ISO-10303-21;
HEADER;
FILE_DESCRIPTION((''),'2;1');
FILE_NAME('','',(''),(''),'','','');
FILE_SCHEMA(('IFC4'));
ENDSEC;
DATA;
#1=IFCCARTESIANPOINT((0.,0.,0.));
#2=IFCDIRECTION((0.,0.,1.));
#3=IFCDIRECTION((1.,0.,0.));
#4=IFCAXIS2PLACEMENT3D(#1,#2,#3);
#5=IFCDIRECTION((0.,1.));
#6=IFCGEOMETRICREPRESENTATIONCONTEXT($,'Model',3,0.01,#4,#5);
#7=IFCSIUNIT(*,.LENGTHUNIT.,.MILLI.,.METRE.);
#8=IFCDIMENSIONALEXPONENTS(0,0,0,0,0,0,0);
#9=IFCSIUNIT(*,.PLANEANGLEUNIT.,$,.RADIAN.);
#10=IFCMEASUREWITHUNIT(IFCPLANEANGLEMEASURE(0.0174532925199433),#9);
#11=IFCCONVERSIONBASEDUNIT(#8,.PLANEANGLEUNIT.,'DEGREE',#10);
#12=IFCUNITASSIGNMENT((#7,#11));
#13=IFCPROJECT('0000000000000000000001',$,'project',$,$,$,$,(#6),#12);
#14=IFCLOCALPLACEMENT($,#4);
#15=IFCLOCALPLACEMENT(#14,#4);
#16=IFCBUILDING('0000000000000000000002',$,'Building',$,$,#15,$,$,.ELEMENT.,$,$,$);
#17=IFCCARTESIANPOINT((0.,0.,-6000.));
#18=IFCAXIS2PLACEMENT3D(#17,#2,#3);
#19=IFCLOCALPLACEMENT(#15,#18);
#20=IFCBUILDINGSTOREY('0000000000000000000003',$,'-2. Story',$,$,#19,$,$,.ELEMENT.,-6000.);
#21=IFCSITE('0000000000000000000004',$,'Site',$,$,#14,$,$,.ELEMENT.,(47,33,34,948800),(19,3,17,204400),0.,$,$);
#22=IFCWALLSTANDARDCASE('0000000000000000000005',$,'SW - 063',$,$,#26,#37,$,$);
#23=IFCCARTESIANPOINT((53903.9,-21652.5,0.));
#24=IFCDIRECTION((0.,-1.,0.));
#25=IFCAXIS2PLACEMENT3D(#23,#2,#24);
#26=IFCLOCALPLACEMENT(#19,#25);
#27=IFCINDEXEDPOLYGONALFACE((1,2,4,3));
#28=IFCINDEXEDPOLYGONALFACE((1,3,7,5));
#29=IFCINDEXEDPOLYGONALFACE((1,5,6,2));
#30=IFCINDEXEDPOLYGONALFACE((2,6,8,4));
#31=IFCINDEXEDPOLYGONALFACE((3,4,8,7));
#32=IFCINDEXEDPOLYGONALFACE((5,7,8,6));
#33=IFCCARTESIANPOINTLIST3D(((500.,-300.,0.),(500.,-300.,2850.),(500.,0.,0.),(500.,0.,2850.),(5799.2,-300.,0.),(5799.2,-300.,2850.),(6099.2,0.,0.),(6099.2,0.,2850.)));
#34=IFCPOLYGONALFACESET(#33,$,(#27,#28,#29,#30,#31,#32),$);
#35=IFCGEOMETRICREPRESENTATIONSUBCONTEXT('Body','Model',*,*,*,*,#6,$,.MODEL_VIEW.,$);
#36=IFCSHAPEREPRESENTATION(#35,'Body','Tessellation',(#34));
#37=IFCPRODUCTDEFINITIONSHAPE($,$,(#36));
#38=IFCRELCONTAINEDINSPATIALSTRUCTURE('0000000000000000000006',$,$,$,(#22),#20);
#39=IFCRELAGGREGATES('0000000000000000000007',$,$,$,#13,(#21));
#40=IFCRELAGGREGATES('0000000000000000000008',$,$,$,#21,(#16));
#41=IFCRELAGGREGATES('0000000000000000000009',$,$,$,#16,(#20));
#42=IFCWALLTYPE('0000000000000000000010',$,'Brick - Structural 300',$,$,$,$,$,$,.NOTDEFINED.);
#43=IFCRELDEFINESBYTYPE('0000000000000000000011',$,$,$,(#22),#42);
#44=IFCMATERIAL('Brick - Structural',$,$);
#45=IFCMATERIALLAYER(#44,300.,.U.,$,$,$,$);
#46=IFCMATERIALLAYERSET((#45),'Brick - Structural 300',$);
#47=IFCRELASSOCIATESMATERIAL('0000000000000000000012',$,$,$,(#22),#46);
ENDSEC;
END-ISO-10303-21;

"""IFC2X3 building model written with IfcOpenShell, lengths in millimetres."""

from ifc_helpers import new_model, entity, si_unit, converted_unit, direction, frame, origin_with_axes, place, context, subcontext, project, spatial, polyline, outline, extrude, material, layer, layer_set, layer_usage, type_object, element, save


model = new_model("IFC2X3")

# Units and contexts
model_context = context("Model", 3, precision=0.01, world=origin_with_axes(), true_north=direction((0.0, 1.0)))
body_context = subcontext(model_context, "Body", "Model", "MODEL_VIEW")
ifc_project = project(units=[si_unit("LENGTHUNIT", "METRE", prefix="MILLI"), converted_unit("PLANEANGLEUNIT", "DEGREE", entity("IfcPlaneAngleMeasure", 0.0174532925199433), si_unit("PLANEANGLEUNIT", "RADIAN"), dimensions=[0, 0, 0, 0, 0, 0, 0])], contexts=[model_context])

# Site, building, storey
site_placement = place(None, origin_with_axes())
site = spatial("IfcSite", under=ifc_project, at=site_placement, Name="Site", CompositionType="ELEMENT", RefLatitude=(47, 33, 34, 948800), RefLongitude=(19, 3, 17, 204400), RefElevation=0.0)
building_placement = place(site_placement, origin_with_axes())
building = spatial("IfcBuilding", under=site, at=building_placement, Name="Building", CompositionType="ELEMENT")
storey_placement = place(building_placement, frame((0.0, 0.0, -6000.0), z_axis=(0.0, 0.0, 1.0), x_axis=(1.0, 0.0, 0.0)))
storey = spatial("IfcBuildingStorey", under=building, at=storey_placement, Name="-2. Story", CompositionType="ELEMENT", Elevation=-6000.0)

# Shared definitions
ifc_material_1 = material(Name="Brick - Structural")
ifc_layer_1 = layer(ifc_material_1, 300.0, ventilated="UNKNOWN")
ifc_layer_set_1 = layer_set([ifc_layer_1], Name="Brick - Structural 300")
wall_type_1 = type_object("IfcWallType", Name="Brick - Structural 300", PredefinedType="NOTDEFINED")

# Wall
ifc_layer_usage_1 = layer_usage(ifc_layer_set_1, "AXIS2", "NEGATIVE", 0.0)
wall_1_placement = place(storey_placement, frame((53903.9, -21652.5, 0.0), z_axis=(0.0, 0.0, 1.0), x_axis=(0.0, -1.0, 0.0)))
element("IfcWallStandardCase", 1, at=wall_1_placement, inside=storey, type_object=wall_type_1, material=ifc_layer_usage_1, Name="SW - 063", context=body_context, shape_type="SweptSolid", body=[
    extrude(outline(polyline([(500.0, -300.0), (5799.2, -300.0), (6099.2, 0.0), (500.0, 0.0), (500.0, -300.0)])), origin_with_axes(), (0.0, 0.0, 1.0), 2850.0),
])

save(model, "model.ifc")
